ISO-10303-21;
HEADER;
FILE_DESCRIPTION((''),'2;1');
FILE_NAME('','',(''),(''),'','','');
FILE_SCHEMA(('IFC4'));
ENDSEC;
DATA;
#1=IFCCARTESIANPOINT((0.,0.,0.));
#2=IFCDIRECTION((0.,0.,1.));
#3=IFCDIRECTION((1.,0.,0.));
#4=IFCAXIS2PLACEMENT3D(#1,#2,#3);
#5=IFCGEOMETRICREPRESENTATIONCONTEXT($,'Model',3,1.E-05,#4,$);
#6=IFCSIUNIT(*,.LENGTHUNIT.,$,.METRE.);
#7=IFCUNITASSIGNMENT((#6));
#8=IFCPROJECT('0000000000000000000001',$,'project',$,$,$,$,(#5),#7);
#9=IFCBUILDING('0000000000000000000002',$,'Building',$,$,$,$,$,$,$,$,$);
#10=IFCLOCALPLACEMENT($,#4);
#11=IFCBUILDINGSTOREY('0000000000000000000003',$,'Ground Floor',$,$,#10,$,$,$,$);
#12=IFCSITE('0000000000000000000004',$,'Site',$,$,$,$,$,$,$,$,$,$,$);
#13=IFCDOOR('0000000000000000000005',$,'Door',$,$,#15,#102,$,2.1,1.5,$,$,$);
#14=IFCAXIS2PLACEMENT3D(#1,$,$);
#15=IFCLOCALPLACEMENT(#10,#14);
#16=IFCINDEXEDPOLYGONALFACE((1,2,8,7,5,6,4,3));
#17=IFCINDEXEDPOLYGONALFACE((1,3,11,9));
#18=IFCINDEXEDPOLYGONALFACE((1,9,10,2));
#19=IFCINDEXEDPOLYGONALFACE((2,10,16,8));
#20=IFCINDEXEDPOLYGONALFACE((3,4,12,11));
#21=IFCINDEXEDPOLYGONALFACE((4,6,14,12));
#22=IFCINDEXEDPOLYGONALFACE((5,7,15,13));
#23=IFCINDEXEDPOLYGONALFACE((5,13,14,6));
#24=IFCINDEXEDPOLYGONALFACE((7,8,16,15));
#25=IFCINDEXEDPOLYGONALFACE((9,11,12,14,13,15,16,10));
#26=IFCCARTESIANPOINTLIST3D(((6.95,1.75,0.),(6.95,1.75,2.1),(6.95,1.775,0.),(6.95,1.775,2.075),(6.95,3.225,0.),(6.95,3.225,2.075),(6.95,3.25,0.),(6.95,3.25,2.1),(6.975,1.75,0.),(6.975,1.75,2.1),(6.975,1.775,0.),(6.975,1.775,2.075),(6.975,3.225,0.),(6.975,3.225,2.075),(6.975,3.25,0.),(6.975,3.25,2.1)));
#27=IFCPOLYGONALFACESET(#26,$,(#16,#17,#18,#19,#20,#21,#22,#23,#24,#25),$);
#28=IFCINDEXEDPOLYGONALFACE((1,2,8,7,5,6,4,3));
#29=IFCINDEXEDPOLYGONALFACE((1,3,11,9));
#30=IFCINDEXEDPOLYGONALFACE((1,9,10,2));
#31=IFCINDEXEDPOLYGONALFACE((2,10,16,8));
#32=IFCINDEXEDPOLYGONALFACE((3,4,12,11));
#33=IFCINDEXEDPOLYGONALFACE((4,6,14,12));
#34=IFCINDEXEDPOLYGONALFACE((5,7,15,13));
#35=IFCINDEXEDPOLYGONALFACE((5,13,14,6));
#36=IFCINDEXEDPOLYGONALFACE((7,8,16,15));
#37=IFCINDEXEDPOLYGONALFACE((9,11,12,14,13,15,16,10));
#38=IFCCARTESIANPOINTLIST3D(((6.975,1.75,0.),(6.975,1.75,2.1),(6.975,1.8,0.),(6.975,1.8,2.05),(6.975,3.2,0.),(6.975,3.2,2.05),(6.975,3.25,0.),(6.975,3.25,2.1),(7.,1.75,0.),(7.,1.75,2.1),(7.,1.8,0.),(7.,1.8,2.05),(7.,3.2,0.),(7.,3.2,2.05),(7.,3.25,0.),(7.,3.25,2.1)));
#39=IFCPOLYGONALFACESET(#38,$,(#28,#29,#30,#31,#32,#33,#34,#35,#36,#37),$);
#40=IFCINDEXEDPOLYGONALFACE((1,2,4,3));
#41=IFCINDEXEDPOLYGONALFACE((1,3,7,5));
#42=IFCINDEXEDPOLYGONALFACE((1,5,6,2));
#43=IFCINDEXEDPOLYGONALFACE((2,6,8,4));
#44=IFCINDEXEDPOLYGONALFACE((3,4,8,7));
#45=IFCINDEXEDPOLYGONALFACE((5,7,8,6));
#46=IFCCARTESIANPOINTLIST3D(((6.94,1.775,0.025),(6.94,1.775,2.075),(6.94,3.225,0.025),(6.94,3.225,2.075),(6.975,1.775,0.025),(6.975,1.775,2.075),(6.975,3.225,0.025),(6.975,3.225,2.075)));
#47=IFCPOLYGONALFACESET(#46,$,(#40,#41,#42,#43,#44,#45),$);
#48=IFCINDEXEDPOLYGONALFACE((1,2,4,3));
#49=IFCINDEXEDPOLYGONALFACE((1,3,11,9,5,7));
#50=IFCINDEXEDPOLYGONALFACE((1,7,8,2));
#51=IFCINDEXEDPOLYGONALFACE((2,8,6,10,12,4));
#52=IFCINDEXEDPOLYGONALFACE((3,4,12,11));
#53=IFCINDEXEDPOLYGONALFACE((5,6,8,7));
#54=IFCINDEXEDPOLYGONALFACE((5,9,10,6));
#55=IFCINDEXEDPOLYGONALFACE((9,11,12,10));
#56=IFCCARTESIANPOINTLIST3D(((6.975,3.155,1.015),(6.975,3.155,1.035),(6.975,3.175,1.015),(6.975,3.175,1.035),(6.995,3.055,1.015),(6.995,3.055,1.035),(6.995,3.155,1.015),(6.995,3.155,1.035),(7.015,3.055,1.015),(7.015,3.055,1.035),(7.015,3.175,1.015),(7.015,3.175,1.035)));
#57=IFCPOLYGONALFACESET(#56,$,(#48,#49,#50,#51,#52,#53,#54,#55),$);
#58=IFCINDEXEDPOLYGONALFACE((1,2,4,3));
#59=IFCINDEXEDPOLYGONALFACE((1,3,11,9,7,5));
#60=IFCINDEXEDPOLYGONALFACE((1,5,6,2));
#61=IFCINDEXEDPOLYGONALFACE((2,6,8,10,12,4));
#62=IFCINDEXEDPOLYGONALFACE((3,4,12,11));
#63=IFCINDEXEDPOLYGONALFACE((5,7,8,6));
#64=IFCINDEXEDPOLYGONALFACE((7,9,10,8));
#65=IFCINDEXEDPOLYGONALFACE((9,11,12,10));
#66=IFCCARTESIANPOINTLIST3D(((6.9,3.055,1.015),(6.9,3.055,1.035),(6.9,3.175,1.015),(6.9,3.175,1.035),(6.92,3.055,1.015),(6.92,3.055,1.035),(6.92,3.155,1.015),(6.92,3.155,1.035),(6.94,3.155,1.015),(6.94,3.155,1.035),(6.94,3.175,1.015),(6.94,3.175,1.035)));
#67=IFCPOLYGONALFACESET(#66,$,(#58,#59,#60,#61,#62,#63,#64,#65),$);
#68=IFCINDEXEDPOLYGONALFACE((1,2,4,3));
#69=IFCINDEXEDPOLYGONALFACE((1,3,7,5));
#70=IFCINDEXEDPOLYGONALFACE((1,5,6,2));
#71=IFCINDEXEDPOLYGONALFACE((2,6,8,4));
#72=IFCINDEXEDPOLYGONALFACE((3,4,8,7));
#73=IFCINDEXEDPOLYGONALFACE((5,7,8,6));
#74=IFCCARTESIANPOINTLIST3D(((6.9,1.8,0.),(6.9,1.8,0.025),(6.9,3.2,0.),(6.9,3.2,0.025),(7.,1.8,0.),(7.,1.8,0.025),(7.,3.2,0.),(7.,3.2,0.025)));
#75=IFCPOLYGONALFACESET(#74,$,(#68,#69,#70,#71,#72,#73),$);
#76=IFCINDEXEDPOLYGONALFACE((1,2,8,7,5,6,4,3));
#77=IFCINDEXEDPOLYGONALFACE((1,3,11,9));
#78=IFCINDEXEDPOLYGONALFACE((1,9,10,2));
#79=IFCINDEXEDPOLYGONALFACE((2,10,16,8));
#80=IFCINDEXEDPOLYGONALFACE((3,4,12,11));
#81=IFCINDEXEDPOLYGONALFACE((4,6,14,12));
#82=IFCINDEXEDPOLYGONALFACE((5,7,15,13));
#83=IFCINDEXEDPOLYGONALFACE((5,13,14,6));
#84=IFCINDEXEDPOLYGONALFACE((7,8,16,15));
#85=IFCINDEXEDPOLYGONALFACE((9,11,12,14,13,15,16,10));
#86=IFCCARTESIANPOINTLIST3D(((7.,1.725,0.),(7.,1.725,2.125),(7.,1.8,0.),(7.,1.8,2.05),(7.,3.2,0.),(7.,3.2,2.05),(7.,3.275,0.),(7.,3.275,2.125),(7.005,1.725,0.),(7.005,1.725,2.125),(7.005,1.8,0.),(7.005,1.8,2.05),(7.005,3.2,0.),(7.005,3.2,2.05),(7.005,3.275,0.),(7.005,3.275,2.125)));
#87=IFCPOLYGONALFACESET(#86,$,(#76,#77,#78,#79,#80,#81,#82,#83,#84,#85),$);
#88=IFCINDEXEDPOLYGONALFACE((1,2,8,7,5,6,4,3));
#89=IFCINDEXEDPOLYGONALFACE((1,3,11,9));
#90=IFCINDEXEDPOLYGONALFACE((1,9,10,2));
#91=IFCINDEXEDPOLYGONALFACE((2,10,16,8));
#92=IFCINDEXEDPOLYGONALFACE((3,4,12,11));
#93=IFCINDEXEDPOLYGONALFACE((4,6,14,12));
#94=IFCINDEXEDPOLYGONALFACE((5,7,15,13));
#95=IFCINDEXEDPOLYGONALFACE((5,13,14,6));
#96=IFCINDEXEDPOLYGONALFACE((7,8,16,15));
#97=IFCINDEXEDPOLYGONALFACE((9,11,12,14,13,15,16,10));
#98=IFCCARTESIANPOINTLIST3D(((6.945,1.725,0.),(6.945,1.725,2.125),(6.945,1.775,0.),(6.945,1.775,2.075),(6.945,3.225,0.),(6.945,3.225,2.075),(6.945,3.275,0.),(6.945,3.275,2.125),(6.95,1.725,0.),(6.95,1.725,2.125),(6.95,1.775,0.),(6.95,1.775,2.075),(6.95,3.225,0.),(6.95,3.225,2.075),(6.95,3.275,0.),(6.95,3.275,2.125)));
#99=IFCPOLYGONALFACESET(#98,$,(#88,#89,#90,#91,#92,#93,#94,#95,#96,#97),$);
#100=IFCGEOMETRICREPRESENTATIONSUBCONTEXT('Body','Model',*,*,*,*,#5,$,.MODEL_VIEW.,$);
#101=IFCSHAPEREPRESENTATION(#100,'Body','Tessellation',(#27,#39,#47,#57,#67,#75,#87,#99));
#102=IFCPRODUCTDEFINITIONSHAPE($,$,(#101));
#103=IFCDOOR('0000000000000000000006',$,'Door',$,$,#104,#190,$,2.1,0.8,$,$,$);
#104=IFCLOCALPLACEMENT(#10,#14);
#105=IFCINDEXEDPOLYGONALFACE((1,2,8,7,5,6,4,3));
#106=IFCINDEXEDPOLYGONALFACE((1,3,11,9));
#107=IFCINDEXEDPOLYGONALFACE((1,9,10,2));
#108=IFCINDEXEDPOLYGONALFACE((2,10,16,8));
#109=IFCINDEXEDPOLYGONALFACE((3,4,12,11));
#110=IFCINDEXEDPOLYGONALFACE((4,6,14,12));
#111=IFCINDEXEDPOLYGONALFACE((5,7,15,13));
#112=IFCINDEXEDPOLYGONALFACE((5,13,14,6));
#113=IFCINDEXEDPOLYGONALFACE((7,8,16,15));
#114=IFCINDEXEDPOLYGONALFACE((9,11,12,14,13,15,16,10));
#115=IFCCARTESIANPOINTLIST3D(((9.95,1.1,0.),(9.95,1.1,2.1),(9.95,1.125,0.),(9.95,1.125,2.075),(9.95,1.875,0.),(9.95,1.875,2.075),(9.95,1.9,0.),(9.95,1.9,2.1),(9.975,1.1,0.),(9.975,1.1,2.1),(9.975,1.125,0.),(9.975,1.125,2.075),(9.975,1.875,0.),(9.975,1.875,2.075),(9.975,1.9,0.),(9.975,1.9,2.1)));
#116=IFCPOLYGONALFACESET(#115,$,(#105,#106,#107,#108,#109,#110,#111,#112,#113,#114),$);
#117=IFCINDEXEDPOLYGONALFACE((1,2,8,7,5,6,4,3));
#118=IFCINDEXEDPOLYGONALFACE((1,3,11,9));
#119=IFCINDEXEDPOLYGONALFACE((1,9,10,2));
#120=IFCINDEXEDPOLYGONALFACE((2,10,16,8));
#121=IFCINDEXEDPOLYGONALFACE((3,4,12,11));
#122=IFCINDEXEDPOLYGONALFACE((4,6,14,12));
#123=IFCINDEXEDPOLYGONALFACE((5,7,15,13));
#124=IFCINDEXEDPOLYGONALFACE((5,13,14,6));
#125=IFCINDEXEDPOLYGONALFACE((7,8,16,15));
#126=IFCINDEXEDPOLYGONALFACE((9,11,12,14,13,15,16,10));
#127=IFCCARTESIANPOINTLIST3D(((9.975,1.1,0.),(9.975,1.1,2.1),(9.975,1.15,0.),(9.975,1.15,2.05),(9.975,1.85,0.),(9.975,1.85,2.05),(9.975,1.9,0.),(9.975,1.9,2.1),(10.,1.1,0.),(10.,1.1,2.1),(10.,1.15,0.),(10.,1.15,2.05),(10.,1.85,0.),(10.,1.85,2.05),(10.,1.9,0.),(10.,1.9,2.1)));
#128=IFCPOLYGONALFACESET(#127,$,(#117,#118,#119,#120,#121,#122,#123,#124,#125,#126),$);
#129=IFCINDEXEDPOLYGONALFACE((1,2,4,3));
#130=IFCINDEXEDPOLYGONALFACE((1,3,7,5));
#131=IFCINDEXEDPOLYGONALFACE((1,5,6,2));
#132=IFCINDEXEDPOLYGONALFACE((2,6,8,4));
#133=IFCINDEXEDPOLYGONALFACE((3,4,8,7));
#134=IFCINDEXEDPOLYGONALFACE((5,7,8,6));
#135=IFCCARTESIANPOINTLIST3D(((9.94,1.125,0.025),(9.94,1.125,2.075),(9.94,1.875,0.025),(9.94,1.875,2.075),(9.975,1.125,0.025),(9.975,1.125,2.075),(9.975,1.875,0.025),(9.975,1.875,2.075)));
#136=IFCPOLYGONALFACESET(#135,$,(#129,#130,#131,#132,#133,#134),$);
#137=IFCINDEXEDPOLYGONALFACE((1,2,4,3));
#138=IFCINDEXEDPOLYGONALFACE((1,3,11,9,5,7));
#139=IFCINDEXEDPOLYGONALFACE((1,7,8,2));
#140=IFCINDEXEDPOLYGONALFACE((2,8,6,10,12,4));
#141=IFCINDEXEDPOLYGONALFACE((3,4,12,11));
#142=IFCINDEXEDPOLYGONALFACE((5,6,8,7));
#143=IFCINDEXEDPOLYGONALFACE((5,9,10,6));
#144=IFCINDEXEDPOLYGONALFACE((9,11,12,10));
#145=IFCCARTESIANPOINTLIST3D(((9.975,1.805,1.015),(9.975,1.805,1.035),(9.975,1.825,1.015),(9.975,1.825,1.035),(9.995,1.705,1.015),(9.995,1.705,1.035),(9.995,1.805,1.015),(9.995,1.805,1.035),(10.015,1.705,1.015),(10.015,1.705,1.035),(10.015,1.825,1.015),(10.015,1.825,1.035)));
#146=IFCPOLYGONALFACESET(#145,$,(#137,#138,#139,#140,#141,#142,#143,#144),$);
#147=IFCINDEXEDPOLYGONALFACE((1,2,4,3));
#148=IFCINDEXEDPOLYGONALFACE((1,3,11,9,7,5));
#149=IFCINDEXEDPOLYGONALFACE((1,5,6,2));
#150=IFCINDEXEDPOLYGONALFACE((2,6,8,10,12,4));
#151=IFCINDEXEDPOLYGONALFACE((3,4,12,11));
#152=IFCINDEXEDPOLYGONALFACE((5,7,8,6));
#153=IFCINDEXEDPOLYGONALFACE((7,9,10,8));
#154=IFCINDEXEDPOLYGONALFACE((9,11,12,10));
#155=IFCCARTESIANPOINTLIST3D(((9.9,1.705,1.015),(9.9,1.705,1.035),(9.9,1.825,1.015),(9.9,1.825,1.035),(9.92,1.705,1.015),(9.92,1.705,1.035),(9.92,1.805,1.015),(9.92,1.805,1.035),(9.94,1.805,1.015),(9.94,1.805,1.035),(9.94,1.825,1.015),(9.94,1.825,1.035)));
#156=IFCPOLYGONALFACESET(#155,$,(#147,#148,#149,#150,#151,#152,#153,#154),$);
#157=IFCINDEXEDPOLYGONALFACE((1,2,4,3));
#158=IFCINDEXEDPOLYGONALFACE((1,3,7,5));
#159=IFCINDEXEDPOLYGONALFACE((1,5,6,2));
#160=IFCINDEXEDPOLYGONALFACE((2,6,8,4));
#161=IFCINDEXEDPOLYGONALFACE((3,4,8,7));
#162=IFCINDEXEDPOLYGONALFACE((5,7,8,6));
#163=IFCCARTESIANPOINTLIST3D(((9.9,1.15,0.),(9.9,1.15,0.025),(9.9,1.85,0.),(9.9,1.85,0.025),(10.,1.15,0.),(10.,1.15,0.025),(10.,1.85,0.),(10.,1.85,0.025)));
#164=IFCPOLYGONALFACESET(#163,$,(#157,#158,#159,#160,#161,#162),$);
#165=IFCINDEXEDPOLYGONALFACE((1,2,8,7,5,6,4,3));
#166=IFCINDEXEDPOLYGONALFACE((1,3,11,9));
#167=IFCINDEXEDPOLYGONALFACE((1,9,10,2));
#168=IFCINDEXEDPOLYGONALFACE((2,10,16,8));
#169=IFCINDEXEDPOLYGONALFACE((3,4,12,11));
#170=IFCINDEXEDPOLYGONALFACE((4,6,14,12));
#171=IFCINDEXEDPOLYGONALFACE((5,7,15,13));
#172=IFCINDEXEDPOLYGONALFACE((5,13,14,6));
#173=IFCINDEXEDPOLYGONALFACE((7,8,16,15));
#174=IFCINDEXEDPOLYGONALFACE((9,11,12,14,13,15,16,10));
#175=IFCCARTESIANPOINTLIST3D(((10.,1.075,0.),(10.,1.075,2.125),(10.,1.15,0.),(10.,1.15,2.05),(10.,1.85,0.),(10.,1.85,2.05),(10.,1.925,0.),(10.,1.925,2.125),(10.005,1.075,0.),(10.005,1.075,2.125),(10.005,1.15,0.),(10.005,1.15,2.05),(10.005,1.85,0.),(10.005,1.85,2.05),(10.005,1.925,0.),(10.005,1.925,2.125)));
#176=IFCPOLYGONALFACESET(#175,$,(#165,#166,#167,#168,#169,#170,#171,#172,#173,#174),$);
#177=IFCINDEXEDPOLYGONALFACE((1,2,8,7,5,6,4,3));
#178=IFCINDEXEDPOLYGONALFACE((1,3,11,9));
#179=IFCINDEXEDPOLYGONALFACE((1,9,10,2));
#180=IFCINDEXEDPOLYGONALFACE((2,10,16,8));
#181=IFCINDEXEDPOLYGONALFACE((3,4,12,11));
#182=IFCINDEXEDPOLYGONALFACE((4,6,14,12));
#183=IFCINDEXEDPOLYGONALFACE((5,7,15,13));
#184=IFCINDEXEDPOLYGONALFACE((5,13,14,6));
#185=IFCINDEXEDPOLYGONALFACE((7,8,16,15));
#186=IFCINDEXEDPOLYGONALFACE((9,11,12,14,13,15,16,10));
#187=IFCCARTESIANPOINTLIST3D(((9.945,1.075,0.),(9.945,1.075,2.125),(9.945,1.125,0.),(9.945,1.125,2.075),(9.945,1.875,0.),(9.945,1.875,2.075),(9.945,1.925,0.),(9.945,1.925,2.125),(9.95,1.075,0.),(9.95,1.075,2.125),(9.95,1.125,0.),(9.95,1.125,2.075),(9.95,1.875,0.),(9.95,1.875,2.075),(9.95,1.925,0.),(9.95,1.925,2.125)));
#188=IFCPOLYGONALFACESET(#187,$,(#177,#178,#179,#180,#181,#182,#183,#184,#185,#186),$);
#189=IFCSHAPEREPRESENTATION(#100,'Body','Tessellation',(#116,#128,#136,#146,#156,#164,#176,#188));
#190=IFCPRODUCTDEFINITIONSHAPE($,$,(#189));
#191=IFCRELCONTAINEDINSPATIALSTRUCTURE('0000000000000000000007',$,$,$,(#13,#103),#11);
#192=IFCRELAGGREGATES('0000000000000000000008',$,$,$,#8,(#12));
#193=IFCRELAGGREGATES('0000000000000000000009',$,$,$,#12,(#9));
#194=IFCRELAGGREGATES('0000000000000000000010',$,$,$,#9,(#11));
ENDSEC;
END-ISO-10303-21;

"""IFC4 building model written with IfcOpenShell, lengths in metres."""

from ifc_helpers import new_model, si_unit, frame, origin_with_axes, place, context, subcontext, project, spatial, line, indexed_curve, outline, extrude, element, save


model = new_model("IFC4")

# Units and contexts
model_context = context("Model", 3, precision=1e-05, world=origin_with_axes())
body_context = subcontext(model_context, "Body", "Model", "MODEL_VIEW")
ifc_project = project(units=[si_unit("LENGTHUNIT", "METRE")], contexts=[model_context])

# Site, building, storey
site = spatial("IfcSite", under=ifc_project, Name="Site")
building = spatial("IfcBuilding", under=site, Name="Building")
storey_placement = place(None, origin_with_axes())
storey = spatial("IfcBuildingStorey", under=building, at=storey_placement, Name="Ground Floor")

# Doors
door_1_placement = place(storey_placement, frame((7.0, 1.75, 0.0), z_axis=(0.0, 0.0, 1.0), x_axis=(0.0, 1.0, 0.0)))
element("IfcDoor", 1, at=door_1_placement, inside=storey, Name="Door", OverallHeight=2.1, OverallWidth=1.5, context=body_context, shape_type="SweptSolid", body=[
    extrude(outline(indexed_curve([(0.0, 0.0), (0.0, 2.1), (1.5, 2.1), (1.5, 0.0), (1.475, 0.0), (1.475, 2.075), (0.025, 2.075), (0.025, 0.0)], segments=[line(1, 2, 3, 4, 5, 6, 7, 8, 1)])), frame((0.0, 0.025, 0.0), z_axis=(0.0, -1.0, 0.0), x_axis=(1.0, 0.0, 0.0)), (0.0, 0.0, -1.0), 0.025),
    extrude(outline(indexed_curve([(0.0, 0.0), (0.0, 2.1), (1.5, 2.1), (1.5, 0.0), (1.45, 0.0), (1.45, 2.05), (0.05, 2.05), (0.05, 0.0)], segments=[line(1, 2, 3, 4, 5, 6, 7, 8, 1)])), frame((0.0, 0.0, 0.0), z_axis=(0.0, -1.0, 0.0), x_axis=(1.0, 0.0, 0.0)), (0.0, 0.0, -1.0), 0.025),
    extrude(outline(indexed_curve([(0.0, 0.0), (1.45, 0.0), (1.45, 0.035), (0.0, 0.035)], segments=[line(1, 2, 3, 4, 1)])), frame((0.025, 0.025, 0.025), z_axis=(0.0, 0.0, 1.0), x_axis=(1.0, 0.0, 0.0)), (0.0, 0.0, 1.0), 2.05),
    extrude(outline(indexed_curve([(0.0, 0.0), (0.0, -0.04), (-0.12, -0.04), (-0.12, -0.02), (-0.02, -0.02), (-0.02, 0.0)], segments=[line(1, 2, 3, 4, 5, 6, 1)])), frame((1.425, 0.025, 1.015), z_axis=(0.0, 0.0, 1.0), x_axis=(1.0, 0.0, 0.0)), (0.0, 0.0, 1.0), 0.02),
    extrude(outline(indexed_curve([(0.0, 0.0), (0.0, 0.04), (-0.12, 0.04), (-0.12, 0.02), (-0.02, 0.02), (-0.02, 0.0)], segments=[line(1, 2, 3, 4, 5, 6, 1)])), frame((1.425, 0.06, 1.015), z_axis=(0.0, 0.0, 1.0), x_axis=(1.0, 0.0, 0.0)), (0.0, 0.0, 1.0), 0.02),
    extrude(outline(indexed_curve([(0.0, 0.0), (1.4, 0.0), (1.4, 0.1), (0.0, 0.1)], segments=[line(1, 2, 3, 4, 1)])), frame((0.05, 0.0, 0.0), z_axis=(0.0, 0.0, 1.0), x_axis=(1.0, 0.0, 0.0)), (0.0, 0.0, 1.0), 0.025),
    extrude(outline(indexed_curve([(0.0, 0.0), (0.0, 2.125), (1.55, 2.125), (1.55, 0.0), (1.475, 0.0), (1.475, 2.05), (0.075, 2.05), (0.075, 0.0)], segments=[line(1, 2, 3, 4, 5, 6, 7, 8, 1)])), frame((-0.025, -0.005, 0.0), z_axis=(0.0, -1.0, 0.0), x_axis=(1.0, 0.0, 0.0)), (0.0, 0.0, -1.0), 0.005),
    extrude(outline(indexed_curve([(0.0, 0.0), (0.0, 2.125), (1.55, 2.125), (1.55, 0.0), (1.5, 0.0), (1.5, 2.075), (0.05, 2.075), (0.05, 0.0)], segments=[line(1, 2, 3, 4, 5, 6, 7, 8, 1)])), frame((-0.025, 0.05, 0.0), z_axis=(0.0, -1.0, 0.0), x_axis=(1.0, 0.0, 0.0)), (0.0, 0.0, -1.0), 0.005),
])
door_2_placement = place(storey_placement, frame((10.0, 1.1, 0.0), z_axis=(0.0, 0.0, 1.0), x_axis=(0.0, 1.0, 0.0)))
element("IfcDoor", 2, at=door_2_placement, inside=storey, Name="Door", OverallHeight=2.1, OverallWidth=0.8, context=body_context, shape_type="SweptSolid", body=[
    extrude(outline(indexed_curve([(0.0, 0.0), (0.0, 2.1), (0.8, 2.1), (0.8, 0.0), (0.775, 0.0), (0.775, 2.075), (0.025, 2.075), (0.025, 0.0)], segments=[line(1, 2, 3, 4, 5, 6, 7, 8, 1)])), frame((0.0, 0.025, 0.0), z_axis=(0.0, -1.0, 0.0), x_axis=(1.0, 0.0, 0.0)), (0.0, 0.0, -1.0), 0.025),
    extrude(outline(indexed_curve([(0.0, 0.0), (0.0, 2.1), (0.8, 2.1), (0.8, 0.0), (0.75, 0.0), (0.75, 2.05), (0.05, 2.05), (0.05, 0.0)], segments=[line(1, 2, 3, 4, 5, 6, 7, 8, 1)])), frame((0.0, 0.0, 0.0), z_axis=(0.0, -1.0, 0.0), x_axis=(1.0, 0.0, 0.0)), (0.0, 0.0, -1.0), 0.025),
    extrude(outline(indexed_curve([(0.0, 0.0), (0.75, 0.0), (0.75, 0.035), (0.0, 0.035)], segments=[line(1, 2, 3, 4, 1)])), frame((0.025, 0.025, 0.025), z_axis=(0.0, 0.0, 1.0), x_axis=(1.0, 0.0, 0.0)), (0.0, 0.0, 1.0), 2.05),
    extrude(outline(indexed_curve([(0.0, 0.0), (0.0, -0.04), (-0.12, -0.04), (-0.12, -0.02), (-0.02, -0.02), (-0.02, 0.0)], segments=[line(1, 2, 3, 4, 5, 6, 1)])), frame((0.725, 0.025, 1.015), z_axis=(0.0, 0.0, 1.0), x_axis=(1.0, 0.0, 0.0)), (0.0, 0.0, 1.0), 0.02),
    extrude(outline(indexed_curve([(0.0, 0.0), (0.0, 0.04), (-0.12, 0.04), (-0.12, 0.02), (-0.02, 0.02), (-0.02, 0.0)], segments=[line(1, 2, 3, 4, 5, 6, 1)])), frame((0.725, 0.06, 1.015), z_axis=(0.0, 0.0, 1.0), x_axis=(1.0, 0.0, 0.0)), (0.0, 0.0, 1.0), 0.02),
    extrude(outline(indexed_curve([(0.0, 0.0), (0.7, 0.0), (0.7, 0.1), (0.0, 0.1)], segments=[line(1, 2, 3, 4, 1)])), frame((0.05, 0.0, 0.0), z_axis=(0.0, 0.0, 1.0), x_axis=(1.0, 0.0, 0.0)), (0.0, 0.0, 1.0), 0.025),
    extrude(outline(indexed_curve([(0.0, 0.0), (0.0, 2.125), (0.85, 2.125), (0.85, 0.0), (0.775, 0.0), (0.775, 2.05), (0.075, 2.05), (0.075, 0.0)], segments=[line(1, 2, 3, 4, 5, 6, 7, 8, 1)])), frame((-0.025, -0.005, 0.0), z_axis=(0.0, -1.0, 0.0), x_axis=(1.0, 0.0, 0.0)), (0.0, 0.0, -1.0), 0.005),
    extrude(outline(indexed_curve([(0.0, 0.0), (0.0, 2.125), (0.85, 2.125), (0.85, 0.0), (0.8, 0.0), (0.8, 2.075), (0.05, 2.075), (0.05, 0.0)], segments=[line(1, 2, 3, 4, 5, 6, 7, 8, 1)])), frame((-0.025, 0.05, 0.0), z_axis=(0.0, -1.0, 0.0), x_axis=(1.0, 0.0, 0.0)), (0.0, 0.0, -1.0), 0.005),
])

save(model, "model.ifc")
